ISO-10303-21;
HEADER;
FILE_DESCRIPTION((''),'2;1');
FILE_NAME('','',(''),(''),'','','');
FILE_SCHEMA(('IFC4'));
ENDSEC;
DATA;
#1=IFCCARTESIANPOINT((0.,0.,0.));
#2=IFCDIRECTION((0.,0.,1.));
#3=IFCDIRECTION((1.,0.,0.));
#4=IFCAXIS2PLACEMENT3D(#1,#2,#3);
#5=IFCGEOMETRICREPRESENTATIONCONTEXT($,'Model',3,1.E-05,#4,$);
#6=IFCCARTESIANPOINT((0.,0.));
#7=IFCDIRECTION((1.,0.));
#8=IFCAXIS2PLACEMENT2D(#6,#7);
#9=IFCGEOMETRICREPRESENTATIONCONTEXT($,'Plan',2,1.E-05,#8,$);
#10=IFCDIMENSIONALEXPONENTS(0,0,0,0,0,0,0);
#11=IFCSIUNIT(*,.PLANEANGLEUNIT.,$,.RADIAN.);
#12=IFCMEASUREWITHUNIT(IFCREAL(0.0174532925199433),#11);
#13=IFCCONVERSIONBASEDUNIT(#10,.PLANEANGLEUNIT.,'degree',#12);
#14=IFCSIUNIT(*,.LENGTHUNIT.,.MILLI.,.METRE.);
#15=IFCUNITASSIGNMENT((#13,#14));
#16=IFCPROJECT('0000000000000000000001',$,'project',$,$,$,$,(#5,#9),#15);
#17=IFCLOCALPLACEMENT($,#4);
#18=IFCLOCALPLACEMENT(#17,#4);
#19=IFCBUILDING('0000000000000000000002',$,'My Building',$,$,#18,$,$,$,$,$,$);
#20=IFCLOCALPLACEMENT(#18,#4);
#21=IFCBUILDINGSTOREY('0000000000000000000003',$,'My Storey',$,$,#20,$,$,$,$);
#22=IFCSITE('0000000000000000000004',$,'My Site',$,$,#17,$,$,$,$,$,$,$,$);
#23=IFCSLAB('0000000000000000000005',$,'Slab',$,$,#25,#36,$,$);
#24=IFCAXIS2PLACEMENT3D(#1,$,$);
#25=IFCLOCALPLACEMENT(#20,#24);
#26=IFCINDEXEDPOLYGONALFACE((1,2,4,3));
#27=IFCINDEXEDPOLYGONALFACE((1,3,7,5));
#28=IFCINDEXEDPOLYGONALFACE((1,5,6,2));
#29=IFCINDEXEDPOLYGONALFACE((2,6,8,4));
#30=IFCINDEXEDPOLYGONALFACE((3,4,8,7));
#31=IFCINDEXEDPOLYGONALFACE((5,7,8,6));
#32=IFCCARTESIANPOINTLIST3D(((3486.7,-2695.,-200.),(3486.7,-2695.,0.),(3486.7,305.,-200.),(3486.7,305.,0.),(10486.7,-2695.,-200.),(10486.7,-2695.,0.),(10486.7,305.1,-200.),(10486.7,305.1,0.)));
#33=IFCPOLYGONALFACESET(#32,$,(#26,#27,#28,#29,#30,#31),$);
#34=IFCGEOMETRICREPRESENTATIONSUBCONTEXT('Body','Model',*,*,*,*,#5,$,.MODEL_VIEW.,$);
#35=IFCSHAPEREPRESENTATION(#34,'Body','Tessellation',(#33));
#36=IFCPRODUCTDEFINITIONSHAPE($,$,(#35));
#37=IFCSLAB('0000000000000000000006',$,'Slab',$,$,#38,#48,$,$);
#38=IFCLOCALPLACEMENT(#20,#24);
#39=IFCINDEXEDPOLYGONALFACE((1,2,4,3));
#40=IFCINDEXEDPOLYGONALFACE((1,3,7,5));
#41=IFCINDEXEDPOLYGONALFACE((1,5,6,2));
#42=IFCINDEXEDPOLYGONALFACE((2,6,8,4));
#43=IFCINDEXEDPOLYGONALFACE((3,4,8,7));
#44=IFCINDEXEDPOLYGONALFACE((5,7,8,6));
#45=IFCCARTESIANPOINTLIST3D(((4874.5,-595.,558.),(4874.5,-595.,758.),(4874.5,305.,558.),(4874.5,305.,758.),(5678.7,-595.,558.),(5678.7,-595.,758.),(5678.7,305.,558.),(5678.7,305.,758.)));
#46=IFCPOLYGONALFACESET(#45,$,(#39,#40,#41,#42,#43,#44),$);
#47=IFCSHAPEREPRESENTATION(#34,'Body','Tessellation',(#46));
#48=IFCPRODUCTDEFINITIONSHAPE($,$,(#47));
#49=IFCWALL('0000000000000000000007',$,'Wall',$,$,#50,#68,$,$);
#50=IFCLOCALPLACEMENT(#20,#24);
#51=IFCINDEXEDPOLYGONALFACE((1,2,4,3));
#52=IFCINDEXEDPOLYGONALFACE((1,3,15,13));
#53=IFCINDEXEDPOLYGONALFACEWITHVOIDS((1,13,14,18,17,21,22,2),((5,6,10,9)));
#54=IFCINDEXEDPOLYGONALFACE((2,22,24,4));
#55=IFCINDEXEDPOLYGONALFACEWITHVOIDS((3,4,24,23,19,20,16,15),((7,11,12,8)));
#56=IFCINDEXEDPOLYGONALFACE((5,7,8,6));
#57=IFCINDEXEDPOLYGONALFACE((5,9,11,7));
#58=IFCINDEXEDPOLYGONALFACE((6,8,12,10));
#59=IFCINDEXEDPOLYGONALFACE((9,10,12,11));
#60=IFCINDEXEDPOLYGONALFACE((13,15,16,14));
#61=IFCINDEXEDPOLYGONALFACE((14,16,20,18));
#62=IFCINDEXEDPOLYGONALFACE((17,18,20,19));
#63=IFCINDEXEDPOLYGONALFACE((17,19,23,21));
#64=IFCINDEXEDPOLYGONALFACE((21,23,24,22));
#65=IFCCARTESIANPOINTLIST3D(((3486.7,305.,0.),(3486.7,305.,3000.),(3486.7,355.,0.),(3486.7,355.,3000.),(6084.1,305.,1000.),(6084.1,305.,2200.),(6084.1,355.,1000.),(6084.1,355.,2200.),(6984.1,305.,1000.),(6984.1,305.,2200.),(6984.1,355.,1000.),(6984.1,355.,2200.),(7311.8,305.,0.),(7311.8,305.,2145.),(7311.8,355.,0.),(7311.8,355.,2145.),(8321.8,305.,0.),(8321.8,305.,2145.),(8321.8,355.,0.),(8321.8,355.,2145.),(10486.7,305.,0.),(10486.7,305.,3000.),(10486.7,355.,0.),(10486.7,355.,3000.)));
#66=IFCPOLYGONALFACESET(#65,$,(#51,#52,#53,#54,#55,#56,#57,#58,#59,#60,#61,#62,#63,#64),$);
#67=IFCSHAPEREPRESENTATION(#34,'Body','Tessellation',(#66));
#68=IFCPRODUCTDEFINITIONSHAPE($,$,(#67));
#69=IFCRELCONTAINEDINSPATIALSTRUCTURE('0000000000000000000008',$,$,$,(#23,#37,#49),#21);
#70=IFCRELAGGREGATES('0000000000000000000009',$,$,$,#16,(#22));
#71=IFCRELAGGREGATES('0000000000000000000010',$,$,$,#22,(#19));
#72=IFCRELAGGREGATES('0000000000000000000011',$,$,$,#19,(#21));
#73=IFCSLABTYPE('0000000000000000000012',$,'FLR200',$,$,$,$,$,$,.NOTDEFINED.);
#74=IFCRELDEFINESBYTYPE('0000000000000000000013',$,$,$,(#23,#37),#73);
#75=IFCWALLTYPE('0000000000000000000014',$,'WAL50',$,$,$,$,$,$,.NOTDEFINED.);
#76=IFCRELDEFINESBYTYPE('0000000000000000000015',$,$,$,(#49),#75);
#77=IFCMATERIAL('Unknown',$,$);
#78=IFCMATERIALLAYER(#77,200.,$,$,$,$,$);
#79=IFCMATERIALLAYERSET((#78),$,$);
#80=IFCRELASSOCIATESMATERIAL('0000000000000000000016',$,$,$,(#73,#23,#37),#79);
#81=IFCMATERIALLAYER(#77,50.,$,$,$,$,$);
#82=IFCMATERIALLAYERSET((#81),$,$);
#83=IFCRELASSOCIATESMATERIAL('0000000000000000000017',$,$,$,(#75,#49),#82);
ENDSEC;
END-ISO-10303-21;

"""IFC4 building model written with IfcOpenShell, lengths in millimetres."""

from ifc_helpers import new_model, entity, si_unit, converted_unit, frame, origin_with_axes, origin_2d_with_axis, place, context, subcontext, project, spatial, line, indexed_curve, outline, extrude, source, transform, mapped, material, layer, layer_set, layer_usage, type_object, element, save


model = new_model("IFC4")

# Units and contexts
model_context = context("Model", 3, precision=1e-05, world=origin_with_axes())
plan_context = context("Plan", 2, precision=1e-05, world=origin_2d_with_axis())
body_context = subcontext(model_context, "Body", "Model", "MODEL_VIEW")
ifc_project = project(units=[converted_unit("PLANEANGLEUNIT", "degree", entity("IfcReal", 0.0174532925199433), si_unit("PLANEANGLEUNIT", "RADIAN"), dimensions=[0, 0, 0, 0, 0, 0, 0]), si_unit("LENGTHUNIT", "METRE", prefix="MILLI")], contexts=[model_context, plan_context])

# Site, building, storey
site_placement = place(None, origin_with_axes())
site = spatial("IfcSite", under=ifc_project, at=site_placement, Name="My Site")
building_placement = place(site_placement, origin_with_axes())
building = spatial("IfcBuilding", under=site, at=building_placement, Name="My Building")
storey_placement = place(building_placement, origin_with_axes())
storey = spatial("IfcBuildingStorey", under=building, at=storey_placement, Name="My Storey")

# Slabs
ifc_material = material(Name="Unknown")
ifc_layer_1 = layer(ifc_material, 200.0)
ifc_layer_set_1 = layer_set([ifc_layer_1])
ifc_layer_usage_1 = layer_usage(ifc_layer_set_1, "AXIS3", "POSITIVE", -200.0)
slab_type = type_object("IfcSlabType", Name="FLR200", PredefinedType="NOTDEFINED", material=ifc_layer_set_1)
slab_1_placement = place(storey_placement, frame((3486.7, 305.0, 0.0), z_axis=(0.0, 0.0, 1.0), x_axis=(1.0, 0.0, 0.0)))
element("IfcSlab", 1, at=slab_1_placement, inside=storey, type_object=slab_type, material=ifc_layer_usage_1, Name="Slab", context=body_context, shape_type="SweptSolid", body=[
    extrude(outline(indexed_curve([(0.0, 0.0), (0.0, -3000.0), (7000.0, -3000.0), (7000.0, 0.0), (0.0, 0.0)])), frame((0.0, 0.0, -200.0), z_axis=(0.0, 0.0, 1.0), x_axis=(1.0, 0.0, 0.0)), (0.0, 0.0, 1.0), 200.0),
])
ifc_layer_usage_2 = layer_usage(ifc_layer_set_1, "AXIS3", "POSITIVE", -200.0)
slab_2_placement = place(storey_placement, frame((4874.5, -595.0, 758.0), z_axis=(0.0, 0.0, 1.0), x_axis=(1.0, 0.0, 0.0)))
element("IfcSlab", 2, at=slab_2_placement, inside=storey, type_object=slab_type, material=ifc_layer_usage_2, Name="Slab", context=body_context, shape_type="SweptSolid", body=[
    extrude(outline(indexed_curve([(0.0, 0.0), (804.2, 0.0), (804.2, 900.0), (0.0, 900.0), (0.0, 0.0)])), frame((0.0, 0.0, -200.0), z_axis=(0.0, 0.0, 1.0), x_axis=(1.0, 0.0, 0.0)), (0.0, 0.0, 1.0), 200.0),
])

# Wall, openings
ifc_layer_2 = layer(ifc_material, 50.0)
ifc_layer_set_2 = layer_set([ifc_layer_2])
ifc_layer_usage_3 = layer_usage(ifc_layer_set_2, "AXIS2", "POSITIVE", 0.0)
wall_type = type_object("IfcWallType", Name="WAL50", PredefinedType="NOTDEFINED", material=ifc_layer_set_2)
wall_placement = place(storey_placement, frame((3486.7, 305.0, 0.0), z_axis=(0.0, 0.0, 1.0), x_axis=(1.0, 0.0, 0.0)))
wall = element("IfcWall", 3, at=wall_placement, inside=storey, type_object=wall_type, material=ifc_layer_usage_3, Name="Wall", context=body_context, shape_type="SweptSolid", body=[
    extrude(outline(indexed_curve([(0.0, 0.0), (0.0, 50.0), (7000.0, 50.0), (7000.0, 0.0)], segments=[line(1, 2, 3, 4, 1)])), origin_with_axes(), (0.0, 0.0, 1.0), 3000.0),
])
shared_shape_1 = source(origin_with_axes(), body_context, "Body", "SweptSolid", [
    extrude(outline(indexed_curve([(0.0, 0.0), (1010.0, 0.0), (1010.0, 2145.0), (0.0, 2145.0)], segments=[line(1, 2, 3, 4, 1)])), frame((0.0, -600.0, 0.0), z_axis=(0.0, -1.0, 0.0), x_axis=(1.0, 0.0, 0.0)), (0.0, 0.0, -1.0), 1200.0),
])
opening_1_placement = place(wall_placement, frame((3825.1, 0.0, 0.0), z_axis=(0.0, 0.0, 1.0), x_axis=(1.0, 0.0, 0.0)))
element("IfcOpeningElement", 4, at=opening_1_placement, cuts=wall, PredefinedType="OPENING", context=body_context, shape_type="MappedRepresentation", body=[
    mapped(shared_shape_1, transform((0.0, 0.0, 0.0), x_axis=(1.0, 0.0, 0.0), y_axis=(0.0, 1.0, 0.0), z_axis=(0.0, 0.0, 1.0), scale=1.0)),
])
shared_shape_2 = source(origin_with_axes(), body_context, "Body", "SweptSolid", [
    extrude(outline(indexed_curve([(0.0, 0.0), (900.0, 0.0), (900.0, 1200.0), (0.0, 1200.0)], segments=[line(1, 2, 3, 4, 1)])), frame((0.0, -600.0, 0.0), z_axis=(0.0, -1.0, 0.0), x_axis=(1.0, 0.0, 0.0)), (0.0, 0.0, -1.0), 1200.0),
])
opening_2_placement = place(wall_placement, frame((2597.4, 0.0, 1000.0), z_axis=(0.0, 0.0, 1.0), x_axis=(1.0, 0.0, 0.0)))
element("IfcOpeningElement", 5, at=opening_2_placement, cuts=wall, PredefinedType="OPENING", context=body_context, shape_type="MappedRepresentation", body=[
    mapped(shared_shape_2, transform((0.0, 0.0, 0.0), x_axis=(1.0, 0.0, 0.0), y_axis=(0.0, 1.0, 0.0), z_axis=(0.0, 0.0, 1.0), scale=1.0)),
])

save(model, "model.ifc")
